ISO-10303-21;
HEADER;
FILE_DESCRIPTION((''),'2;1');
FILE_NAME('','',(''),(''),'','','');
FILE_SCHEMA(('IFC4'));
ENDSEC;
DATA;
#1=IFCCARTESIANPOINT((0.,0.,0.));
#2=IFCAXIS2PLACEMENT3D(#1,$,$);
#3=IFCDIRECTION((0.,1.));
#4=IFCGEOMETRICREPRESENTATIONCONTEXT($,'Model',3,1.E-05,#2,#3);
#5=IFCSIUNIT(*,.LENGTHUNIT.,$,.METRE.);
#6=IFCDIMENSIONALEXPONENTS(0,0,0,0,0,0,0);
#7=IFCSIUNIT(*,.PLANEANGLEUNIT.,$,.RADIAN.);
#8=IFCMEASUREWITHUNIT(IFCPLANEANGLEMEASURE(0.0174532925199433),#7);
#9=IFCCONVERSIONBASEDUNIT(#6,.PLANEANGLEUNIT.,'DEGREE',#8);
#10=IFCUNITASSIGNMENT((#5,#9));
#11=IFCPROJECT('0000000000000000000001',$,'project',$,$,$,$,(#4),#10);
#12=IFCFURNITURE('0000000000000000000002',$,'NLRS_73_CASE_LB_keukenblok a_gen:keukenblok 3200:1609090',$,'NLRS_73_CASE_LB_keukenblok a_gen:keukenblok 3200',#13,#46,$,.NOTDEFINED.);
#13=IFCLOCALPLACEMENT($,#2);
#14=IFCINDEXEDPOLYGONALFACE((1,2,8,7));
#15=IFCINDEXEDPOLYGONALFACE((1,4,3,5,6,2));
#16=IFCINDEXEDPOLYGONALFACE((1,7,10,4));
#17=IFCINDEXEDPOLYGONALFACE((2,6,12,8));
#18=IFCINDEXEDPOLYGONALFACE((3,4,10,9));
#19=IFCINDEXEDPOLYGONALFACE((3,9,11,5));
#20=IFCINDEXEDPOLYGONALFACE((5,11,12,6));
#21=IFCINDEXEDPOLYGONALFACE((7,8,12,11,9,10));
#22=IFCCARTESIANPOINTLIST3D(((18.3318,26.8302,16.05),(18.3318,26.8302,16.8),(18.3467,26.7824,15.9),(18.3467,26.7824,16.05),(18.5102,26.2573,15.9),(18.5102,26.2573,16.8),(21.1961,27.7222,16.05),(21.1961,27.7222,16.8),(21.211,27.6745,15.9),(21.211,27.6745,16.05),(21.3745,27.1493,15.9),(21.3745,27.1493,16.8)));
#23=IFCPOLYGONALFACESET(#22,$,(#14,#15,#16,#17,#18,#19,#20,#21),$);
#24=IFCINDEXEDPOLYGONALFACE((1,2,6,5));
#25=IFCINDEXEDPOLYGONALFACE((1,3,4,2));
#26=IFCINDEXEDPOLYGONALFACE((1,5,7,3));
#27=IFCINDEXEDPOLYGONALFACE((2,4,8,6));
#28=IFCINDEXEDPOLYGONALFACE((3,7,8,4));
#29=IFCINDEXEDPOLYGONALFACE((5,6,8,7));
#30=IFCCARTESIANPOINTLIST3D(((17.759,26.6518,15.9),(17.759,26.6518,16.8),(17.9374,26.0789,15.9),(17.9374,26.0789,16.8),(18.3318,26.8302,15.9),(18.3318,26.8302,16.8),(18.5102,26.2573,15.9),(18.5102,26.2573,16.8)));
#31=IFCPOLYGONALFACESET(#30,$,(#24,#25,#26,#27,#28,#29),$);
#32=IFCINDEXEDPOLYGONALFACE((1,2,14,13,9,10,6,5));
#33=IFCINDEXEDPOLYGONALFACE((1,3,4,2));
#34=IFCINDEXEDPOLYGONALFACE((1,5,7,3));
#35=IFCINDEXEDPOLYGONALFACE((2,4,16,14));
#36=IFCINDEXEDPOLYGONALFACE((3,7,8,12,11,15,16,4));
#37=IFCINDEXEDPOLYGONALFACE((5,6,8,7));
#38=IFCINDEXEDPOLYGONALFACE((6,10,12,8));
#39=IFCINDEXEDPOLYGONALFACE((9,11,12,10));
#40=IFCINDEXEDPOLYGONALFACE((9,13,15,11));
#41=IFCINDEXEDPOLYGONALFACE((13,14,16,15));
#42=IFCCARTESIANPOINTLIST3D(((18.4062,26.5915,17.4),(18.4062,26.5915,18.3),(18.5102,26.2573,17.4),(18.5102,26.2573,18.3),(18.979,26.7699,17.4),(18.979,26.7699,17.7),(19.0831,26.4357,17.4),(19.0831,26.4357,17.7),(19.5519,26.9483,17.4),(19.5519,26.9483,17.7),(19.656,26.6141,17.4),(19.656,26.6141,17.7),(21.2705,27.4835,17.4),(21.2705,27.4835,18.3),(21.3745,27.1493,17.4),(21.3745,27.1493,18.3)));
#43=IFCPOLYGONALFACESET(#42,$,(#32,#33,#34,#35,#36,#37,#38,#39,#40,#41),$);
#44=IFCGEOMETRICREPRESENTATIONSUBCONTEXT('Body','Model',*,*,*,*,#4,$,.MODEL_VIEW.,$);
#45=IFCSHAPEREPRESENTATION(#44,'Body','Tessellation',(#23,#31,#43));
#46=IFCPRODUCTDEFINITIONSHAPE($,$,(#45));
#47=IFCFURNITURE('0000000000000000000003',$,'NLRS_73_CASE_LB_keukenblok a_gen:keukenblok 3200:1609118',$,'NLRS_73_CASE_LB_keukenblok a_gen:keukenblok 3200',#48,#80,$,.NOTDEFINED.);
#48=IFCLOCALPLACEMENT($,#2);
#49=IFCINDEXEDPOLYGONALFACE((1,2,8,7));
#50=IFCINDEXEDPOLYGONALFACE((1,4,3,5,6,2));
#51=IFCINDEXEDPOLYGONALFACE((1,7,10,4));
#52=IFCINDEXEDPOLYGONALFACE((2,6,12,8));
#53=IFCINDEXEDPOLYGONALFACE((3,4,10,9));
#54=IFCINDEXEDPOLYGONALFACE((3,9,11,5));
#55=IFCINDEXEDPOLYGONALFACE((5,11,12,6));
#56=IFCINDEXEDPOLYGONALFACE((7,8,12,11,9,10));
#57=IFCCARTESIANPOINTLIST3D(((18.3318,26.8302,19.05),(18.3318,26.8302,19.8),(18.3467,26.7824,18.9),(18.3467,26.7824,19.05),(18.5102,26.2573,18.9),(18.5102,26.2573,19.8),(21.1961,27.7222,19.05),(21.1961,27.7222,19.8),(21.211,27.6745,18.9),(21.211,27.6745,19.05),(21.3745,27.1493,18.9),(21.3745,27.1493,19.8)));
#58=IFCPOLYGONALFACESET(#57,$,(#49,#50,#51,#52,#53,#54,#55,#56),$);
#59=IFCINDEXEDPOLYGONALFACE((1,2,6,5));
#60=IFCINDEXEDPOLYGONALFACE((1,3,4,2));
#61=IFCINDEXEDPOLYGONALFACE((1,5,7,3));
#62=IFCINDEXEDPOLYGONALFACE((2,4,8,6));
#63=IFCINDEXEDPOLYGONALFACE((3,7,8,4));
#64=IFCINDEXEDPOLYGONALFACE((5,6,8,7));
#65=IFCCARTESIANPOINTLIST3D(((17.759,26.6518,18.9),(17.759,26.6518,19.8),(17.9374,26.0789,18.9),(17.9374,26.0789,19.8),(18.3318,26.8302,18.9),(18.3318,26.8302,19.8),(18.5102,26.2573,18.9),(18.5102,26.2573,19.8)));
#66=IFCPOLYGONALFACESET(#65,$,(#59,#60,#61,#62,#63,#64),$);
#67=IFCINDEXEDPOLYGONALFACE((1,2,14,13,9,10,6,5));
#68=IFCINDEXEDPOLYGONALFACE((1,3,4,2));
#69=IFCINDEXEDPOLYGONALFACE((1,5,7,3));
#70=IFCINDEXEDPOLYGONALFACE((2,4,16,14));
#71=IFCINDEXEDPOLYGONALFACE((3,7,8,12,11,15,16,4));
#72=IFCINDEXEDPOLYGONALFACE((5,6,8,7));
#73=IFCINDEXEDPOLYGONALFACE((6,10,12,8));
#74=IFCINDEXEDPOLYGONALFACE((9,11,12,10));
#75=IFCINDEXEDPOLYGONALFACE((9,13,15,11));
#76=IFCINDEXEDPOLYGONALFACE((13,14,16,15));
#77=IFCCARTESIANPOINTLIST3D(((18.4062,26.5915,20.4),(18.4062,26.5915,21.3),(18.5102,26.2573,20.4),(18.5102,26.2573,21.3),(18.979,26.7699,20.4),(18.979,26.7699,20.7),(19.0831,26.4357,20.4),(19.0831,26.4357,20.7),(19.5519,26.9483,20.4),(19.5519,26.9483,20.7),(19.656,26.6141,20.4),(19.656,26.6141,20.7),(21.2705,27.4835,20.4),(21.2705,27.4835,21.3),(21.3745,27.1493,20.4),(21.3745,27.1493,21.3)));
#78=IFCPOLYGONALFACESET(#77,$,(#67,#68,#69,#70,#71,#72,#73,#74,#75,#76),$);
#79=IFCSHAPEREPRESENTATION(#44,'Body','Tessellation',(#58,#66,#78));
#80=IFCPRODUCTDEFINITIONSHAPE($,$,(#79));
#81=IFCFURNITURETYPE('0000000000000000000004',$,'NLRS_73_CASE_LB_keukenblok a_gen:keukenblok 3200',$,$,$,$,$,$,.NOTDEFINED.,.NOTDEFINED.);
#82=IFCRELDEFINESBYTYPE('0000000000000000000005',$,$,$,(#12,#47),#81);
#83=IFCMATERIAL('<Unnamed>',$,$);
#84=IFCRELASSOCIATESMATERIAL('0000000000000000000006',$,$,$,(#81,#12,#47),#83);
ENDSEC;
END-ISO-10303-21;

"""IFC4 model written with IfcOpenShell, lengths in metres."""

from ifc_helpers import new_model, entity, si_unit, converted_unit, direction, frame, origin, place, context, subcontext, project, indexed_curve, outline, extrude, source, transform, mapped, material, type_object, element, save


model = new_model("IFC4")

# Units and contexts
model_context = context("Model", 3, precision=1e-05, world=origin(), true_north=direction((0.0, 1.0)))
body_context = subcontext(model_context, "Body", "Model", "MODEL_VIEW")
ifc_project = project(units=[si_unit("LENGTHUNIT", "METRE"), converted_unit("PLANEANGLEUNIT", "DEGREE", entity("IfcPlaneAngleMeasure", 0.0174532925199433), si_unit("PLANEANGLEUNIT", "RADIAN"), dimensions=[0, 0, 0, 0, 0, 0, 0])], contexts=[model_context])

# Shared definitions
ifc_material = material(Name="<Unnamed>")
placement_1 = place(None, frame((13.1348, 11.9886, 0.0), z_axis=(0.0, 0.0, 1.0), x_axis=(0.954771, 0.297342, 0.0)))
placement_2 = place(placement_1, origin())
placement_3 = place(placement_2, frame((0.0, 0.0, 15.9)))
placement_4 = place(placement_2, frame((0.0, 0.0, 18.9)))

# Furniture
furniture_type = type_object("IfcFurnitureType", Name="NLRS_73_CASE_LB_keukenblok a_gen:keukenblok 3200", AssemblyPlace="NOTDEFINED", PredefinedType="NOTDEFINED", material=ifc_material)
shared_shape_1 = source(origin(), body_context, "Body", "SweptSolid", [
    extrude(outline(indexed_curve([(-0.1667, -0.35), (0.3833, -0.35), (0.3833, 0.55), (-0.2167, 0.55), (-0.2167, -0.2), (-0.1667, -0.2), (-0.1667, -0.35)], self_intersect=False)), frame((0.0, -0.3833, 0.35), z_axis=(1.0, 0.0, 0.0), x_axis=(0.0, 1.0, 0.0)), (0.0, 0.0, 1.0), 3.0),
    extrude(outline(indexed_curve([(-0.3, -0.3), (0.3, -0.3), (0.3, 0.3), (-0.3, 0.3), (-0.3, -0.3)], self_intersect=False)), frame((3.3, -0.3, 0.0), z_axis=(0.0, 0.0, 1.0), x_axis=(-1.0, 0.0, 0.0)), (0.0, 0.0, 1.0), 0.9),
    extrude(outline(indexed_curve([(-0.6, -1.2), (0.3, -1.2), (0.3, -0.6), (0.0, -0.6), (0.0, 0.0), (0.3, 0.0), (0.3, 1.8), (-0.6, 1.8), (-0.6, -1.2)], self_intersect=False)), frame((1.8, -0.35, 1.8), z_axis=(0.0, 1.0, 0.0), x_axis=(0.0, 0.0, -1.0)), (0.0, 0.0, 1.0), 0.35),
])
placement_5 = place(placement_3, origin())
furniture_1_placement = place(placement_5, frame((12.375, 12.025, 0.0), z_axis=(0.0, 0.0, 1.0), x_axis=(-1.0, 0.0, 0.0)))
element("IfcFurniture", 1, at=furniture_1_placement, type_object=furniture_type, material=ifc_material, Name="NLRS_73_CASE_LB_keukenblok a_gen:keukenblok 3200:1609090", ObjectType="NLRS_73_CASE_LB_keukenblok a_gen:keukenblok 3200", PredefinedType="NOTDEFINED", context=body_context, shape_type="MappedRepresentation", body=[
    mapped(shared_shape_1, transform((0.0, 0.0, 0.0), scale=1.0)),
])
placement_6 = place(placement_4, origin())
furniture_2_placement = place(placement_6, frame((12.375, 12.025, 0.0), z_axis=(0.0, 0.0, 1.0), x_axis=(-1.0, 0.0, 0.0)))
element("IfcFurniture", 2, at=furniture_2_placement, type_object=furniture_type, material=ifc_material, Name="NLRS_73_CASE_LB_keukenblok a_gen:keukenblok 3200:1609118", ObjectType="NLRS_73_CASE_LB_keukenblok a_gen:keukenblok 3200", PredefinedType="NOTDEFINED", context=body_context, shape_type="MappedRepresentation", body=[
    mapped(shared_shape_1, transform((0.0, 0.0, 0.0), scale=1.0)),
])

save(model, "model.ifc")
